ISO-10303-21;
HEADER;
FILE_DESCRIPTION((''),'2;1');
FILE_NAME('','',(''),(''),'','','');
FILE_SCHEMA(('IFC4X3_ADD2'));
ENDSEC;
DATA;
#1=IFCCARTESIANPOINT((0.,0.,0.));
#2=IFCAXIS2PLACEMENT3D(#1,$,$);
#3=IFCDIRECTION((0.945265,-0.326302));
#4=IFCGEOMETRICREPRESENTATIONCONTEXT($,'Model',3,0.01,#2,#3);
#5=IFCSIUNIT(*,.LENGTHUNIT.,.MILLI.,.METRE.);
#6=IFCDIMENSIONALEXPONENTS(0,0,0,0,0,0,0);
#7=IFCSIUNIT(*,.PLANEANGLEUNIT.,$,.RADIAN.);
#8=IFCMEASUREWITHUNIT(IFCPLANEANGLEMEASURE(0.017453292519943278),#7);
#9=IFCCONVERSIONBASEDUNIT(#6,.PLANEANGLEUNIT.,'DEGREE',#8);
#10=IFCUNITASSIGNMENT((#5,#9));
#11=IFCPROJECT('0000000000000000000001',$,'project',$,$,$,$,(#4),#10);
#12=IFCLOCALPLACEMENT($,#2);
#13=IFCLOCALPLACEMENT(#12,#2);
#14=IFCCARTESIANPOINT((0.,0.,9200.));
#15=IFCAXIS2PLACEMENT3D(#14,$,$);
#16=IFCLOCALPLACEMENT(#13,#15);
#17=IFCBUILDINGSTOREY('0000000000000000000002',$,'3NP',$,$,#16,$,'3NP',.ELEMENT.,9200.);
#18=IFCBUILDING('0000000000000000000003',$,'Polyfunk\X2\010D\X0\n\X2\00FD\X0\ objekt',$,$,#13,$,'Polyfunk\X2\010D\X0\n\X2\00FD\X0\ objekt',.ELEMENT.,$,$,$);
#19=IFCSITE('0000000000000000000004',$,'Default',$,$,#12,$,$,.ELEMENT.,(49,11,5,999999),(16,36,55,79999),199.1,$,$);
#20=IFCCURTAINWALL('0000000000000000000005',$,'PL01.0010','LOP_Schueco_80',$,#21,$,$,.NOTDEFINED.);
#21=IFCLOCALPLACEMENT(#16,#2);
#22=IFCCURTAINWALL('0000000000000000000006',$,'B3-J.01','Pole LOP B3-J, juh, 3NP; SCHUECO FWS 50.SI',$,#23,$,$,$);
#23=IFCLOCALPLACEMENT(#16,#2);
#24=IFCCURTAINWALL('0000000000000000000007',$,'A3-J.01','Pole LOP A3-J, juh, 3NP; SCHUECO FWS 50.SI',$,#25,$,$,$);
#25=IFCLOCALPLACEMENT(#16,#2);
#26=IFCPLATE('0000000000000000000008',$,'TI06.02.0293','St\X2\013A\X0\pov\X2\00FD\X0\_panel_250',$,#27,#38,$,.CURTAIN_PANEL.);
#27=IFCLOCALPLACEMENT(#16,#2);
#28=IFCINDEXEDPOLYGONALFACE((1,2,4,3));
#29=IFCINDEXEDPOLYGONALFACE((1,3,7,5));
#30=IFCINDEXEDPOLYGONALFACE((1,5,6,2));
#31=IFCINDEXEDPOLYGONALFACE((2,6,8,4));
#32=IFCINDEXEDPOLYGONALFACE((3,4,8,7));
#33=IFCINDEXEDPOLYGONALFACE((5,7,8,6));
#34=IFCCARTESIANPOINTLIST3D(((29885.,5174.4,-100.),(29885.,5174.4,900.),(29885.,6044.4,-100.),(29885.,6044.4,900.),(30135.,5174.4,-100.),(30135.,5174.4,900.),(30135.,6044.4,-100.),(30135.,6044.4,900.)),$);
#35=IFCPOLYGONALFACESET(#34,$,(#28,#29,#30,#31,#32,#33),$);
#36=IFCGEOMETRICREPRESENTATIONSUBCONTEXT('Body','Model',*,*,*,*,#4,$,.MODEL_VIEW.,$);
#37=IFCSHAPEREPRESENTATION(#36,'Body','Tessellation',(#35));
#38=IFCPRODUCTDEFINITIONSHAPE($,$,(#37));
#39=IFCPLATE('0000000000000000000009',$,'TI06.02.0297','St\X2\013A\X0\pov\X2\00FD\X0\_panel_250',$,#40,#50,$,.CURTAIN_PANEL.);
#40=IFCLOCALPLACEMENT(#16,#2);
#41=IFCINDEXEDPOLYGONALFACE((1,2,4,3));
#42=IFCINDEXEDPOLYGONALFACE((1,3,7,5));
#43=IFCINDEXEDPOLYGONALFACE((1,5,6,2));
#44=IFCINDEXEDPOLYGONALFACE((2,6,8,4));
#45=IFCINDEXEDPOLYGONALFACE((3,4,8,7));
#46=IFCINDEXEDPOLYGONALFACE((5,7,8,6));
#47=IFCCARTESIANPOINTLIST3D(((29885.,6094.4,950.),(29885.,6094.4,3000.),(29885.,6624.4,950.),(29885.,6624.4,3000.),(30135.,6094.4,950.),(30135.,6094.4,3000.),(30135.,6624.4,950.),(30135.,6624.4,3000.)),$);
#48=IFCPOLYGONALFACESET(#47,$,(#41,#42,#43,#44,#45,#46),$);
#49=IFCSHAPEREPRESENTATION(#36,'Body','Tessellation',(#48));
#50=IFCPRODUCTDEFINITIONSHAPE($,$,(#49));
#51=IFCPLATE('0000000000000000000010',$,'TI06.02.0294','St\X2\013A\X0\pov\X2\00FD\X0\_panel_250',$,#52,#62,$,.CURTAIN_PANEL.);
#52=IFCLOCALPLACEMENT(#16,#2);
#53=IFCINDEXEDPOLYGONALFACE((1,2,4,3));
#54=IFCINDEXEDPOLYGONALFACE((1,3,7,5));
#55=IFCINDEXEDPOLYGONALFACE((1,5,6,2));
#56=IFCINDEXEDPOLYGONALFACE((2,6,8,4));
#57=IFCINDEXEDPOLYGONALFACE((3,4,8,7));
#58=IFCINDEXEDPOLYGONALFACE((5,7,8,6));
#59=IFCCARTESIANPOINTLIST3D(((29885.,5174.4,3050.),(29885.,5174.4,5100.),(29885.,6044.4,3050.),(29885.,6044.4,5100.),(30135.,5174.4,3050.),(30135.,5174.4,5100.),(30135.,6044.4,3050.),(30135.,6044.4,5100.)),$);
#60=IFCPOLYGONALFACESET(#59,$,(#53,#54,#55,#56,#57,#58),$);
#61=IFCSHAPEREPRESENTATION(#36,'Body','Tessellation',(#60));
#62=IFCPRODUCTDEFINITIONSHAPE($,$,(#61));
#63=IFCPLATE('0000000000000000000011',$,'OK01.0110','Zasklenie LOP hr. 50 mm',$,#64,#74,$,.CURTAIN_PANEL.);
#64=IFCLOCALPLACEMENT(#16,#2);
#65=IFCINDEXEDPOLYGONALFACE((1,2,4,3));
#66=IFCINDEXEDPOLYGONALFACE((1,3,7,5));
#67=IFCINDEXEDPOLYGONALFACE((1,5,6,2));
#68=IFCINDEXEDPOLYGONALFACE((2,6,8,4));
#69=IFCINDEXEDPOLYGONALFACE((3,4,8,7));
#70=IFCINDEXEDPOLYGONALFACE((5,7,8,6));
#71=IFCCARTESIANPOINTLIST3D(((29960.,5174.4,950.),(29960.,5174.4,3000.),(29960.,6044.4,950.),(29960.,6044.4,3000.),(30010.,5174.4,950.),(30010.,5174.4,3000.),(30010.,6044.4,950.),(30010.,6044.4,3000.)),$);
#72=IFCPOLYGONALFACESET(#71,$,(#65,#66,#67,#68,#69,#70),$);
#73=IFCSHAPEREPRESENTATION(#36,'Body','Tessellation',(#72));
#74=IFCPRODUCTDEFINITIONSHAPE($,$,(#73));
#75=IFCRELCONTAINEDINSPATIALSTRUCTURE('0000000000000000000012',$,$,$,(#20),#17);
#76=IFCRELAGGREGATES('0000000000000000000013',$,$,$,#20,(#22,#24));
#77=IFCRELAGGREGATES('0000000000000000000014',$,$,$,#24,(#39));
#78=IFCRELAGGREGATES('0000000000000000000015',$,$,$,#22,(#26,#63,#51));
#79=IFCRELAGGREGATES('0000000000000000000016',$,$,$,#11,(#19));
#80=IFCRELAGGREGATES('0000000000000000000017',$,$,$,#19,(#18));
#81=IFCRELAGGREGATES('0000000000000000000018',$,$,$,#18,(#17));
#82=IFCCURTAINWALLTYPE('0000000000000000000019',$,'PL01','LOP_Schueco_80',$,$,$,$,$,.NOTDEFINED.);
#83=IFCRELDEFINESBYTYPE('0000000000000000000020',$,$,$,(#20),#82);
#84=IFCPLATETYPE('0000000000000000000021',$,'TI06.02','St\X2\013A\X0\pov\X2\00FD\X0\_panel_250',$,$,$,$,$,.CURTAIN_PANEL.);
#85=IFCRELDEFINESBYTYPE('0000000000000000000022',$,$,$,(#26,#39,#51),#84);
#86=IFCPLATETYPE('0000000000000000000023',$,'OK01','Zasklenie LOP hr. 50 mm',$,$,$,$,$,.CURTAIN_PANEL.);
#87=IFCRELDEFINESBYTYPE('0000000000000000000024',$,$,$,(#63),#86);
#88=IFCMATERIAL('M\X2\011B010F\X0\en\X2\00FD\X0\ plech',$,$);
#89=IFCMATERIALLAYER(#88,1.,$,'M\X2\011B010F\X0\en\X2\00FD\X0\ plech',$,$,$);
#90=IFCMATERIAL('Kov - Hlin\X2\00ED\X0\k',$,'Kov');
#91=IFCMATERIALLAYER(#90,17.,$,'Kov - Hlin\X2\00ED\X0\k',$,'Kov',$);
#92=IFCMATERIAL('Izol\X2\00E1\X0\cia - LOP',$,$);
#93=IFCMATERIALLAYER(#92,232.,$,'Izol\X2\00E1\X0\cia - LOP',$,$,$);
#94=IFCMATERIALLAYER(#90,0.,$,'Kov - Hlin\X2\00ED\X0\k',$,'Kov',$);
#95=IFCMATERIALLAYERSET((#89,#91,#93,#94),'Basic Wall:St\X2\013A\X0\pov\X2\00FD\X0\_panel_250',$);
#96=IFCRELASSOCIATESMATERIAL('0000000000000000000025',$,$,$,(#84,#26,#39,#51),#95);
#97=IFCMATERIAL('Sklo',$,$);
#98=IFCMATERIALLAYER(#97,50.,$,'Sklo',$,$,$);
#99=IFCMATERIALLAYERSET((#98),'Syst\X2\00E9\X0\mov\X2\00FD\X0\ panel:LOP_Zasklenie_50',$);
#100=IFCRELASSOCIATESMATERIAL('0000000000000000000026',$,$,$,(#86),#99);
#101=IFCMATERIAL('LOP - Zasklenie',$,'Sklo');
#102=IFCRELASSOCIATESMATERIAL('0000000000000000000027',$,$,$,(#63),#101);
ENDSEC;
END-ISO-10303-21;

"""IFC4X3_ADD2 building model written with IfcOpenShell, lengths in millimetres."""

from ifc_helpers import new_model, entity, si_unit, converted_unit, direction, frame, frame_2d, origin, origin_2d_with_axis, place, context, subcontext, project, spatial, rectangle, extrude, source, transform, mapped, material, layer, layer_set, layer_usage, type_object, type_shapes, element, aggregate, save


model = new_model("IFC4X3_ADD2")

# Units and contexts
model_context = context("Model", 3, precision=0.01, world=origin(), true_north=direction((0.945265, -0.326302)))
body_context = subcontext(model_context, "Body", "Model", "MODEL_VIEW")
ifc_project = project(units=[si_unit("LENGTHUNIT", "METRE", prefix="MILLI"), converted_unit("PLANEANGLEUNIT", "DEGREE", entity("IfcPlaneAngleMeasure", 0.017453292519943278), si_unit("PLANEANGLEUNIT", "RADIAN"), dimensions=[0, 0, 0, 0, 0, 0, 0])], contexts=[model_context])

# Site, building, storey
site_placement = place(None, origin())
site = spatial("IfcSite", under=ifc_project, at=site_placement, Name="Default", CompositionType="ELEMENT", RefLatitude=(49, 11, 5, 999999), RefLongitude=(16, 36, 55, 79999), RefElevation=199.1)
building_placement = place(site_placement, origin())
building = spatial("IfcBuilding", under=site, at=building_placement, Name="Polyfunkčný objekt", LongName="Polyfunkčný objekt", CompositionType="ELEMENT")
storey_placement = place(building_placement, frame((0.0, 0.0, 9200.0)))
storey = spatial("IfcBuildingStorey", under=building, at=storey_placement, Name="3NP", LongName="3NP", CompositionType="ELEMENT", Elevation=9200.0)

# Curtain walls, plates
curtain_wall_type = type_object("IfcCurtainWallType", Name="PL01", Description="LOP_Schueco_80", PredefinedType="NOTDEFINED")
curtain_wall_1_placement = place(storey_placement, frame((0.0, 0.0, -9200.0)))
curtain_wall_1 = element("IfcCurtainWall", 1, at=curtain_wall_1_placement, inside=storey, type_object=curtain_wall_type, Name="PL01.0010", Description="LOP_Schueco_80", PredefinedType="NOTDEFINED")
curtain_wall_2 = element("IfcCurtainWall", 2, Name="B3-J.01", Description="Pole LOP B3-J, juh, 3NP; SCHUECO FWS 50.SI")
curtain_wall_3 = element("IfcCurtainWall", 3, Name="A3-J.01", Description="Pole LOP A3-J, juh, 3NP; SCHUECO FWS 50.SI")
aggregate(curtain_wall_1, [curtain_wall_2, curtain_wall_3])
ifc_material_1 = material(Name="Měďený plech")
ifc_layer_1 = layer(ifc_material_1, 1.0, Name="Měďený plech")
ifc_material_2 = material(Name="Kov - Hliník", Category="Kov")
ifc_layer_2 = layer(ifc_material_2, 17.0, Name="Kov - Hliník", Category="Kov")
ifc_material_3 = material(Name="Izolácia - LOP")
ifc_layer_3 = layer(ifc_material_3, 232.0, Name="Izolácia - LOP")
ifc_layer_4 = layer(ifc_material_2, 0.0, Name="Kov - Hliník", Category="Kov")
ifc_layer_set_1 = layer_set([ifc_layer_1, ifc_layer_2, ifc_layer_3, ifc_layer_4], Name="Basic Wall:Stĺpový_panel_250")
ifc_layer_usage_1 = layer_usage(ifc_layer_set_1, "AXIS2", "POSITIVE", -125.0)
plate_type_1 = type_object("IfcPlateType", Name="TI06.02", Description="Stĺpový_panel_250", PredefinedType="CURTAIN_PANEL", material=ifc_layer_set_1)
plate_1_placement = place(storey_placement, frame((30010.0, 6044.4, -100.0), z_axis=(0.0, 0.0, 1.0), x_axis=(0.0, -1.0, 0.0)))
plate_1 = element("IfcPlate", 4, at=plate_1_placement, type_object=plate_type_1, material=ifc_layer_usage_1, Name="TI06.02.0293", Description="Stĺpový_panel_250", PredefinedType="CURTAIN_PANEL", context=body_context, shape_type="SweptSolid", body=[
    extrude(rectangle(XDim=250.0, YDim=870.0, at=frame_2d((0.0, 0.0), x_axis=(1.0, 0.0))), frame((435.0, 0.0, 0.0), z_axis=(0.0, 0.0, 1.0), x_axis=(0.0, 1.0, 0.0)), (0.0, 0.0, 1.0), 1000.0),
])
ifc_layer_usage_2 = layer_usage(ifc_layer_set_1, "AXIS2", "POSITIVE", -125.0)
plate_2_placement = place(storey_placement, frame((30010.0, 6624.4, 950.0), z_axis=(0.0, 0.0, 1.0), x_axis=(0.0, -1.0, 0.0)))
plate_2 = element("IfcPlate", 5, at=plate_2_placement, type_object=plate_type_1, material=ifc_layer_usage_2, Name="TI06.02.0297", Description="Stĺpový_panel_250", PredefinedType="CURTAIN_PANEL", context=body_context, shape_type="SweptSolid", body=[
    extrude(rectangle(XDim=250.0, YDim=530.0, at=frame_2d((0.0, 0.0), x_axis=(1.0, 0.0))), frame((265.0, 0.0, 0.0), z_axis=(0.0, 0.0, 1.0), x_axis=(0.0, 1.0, 0.0)), (0.0, 0.0, 1.0), 2050.0),
])
aggregate(curtain_wall_3, [plate_2])
ifc_layer_usage_3 = layer_usage(ifc_layer_set_1, "AXIS2", "POSITIVE", -125.0)
plate_3_placement = place(storey_placement, frame((30010.0, 6044.4, 3050.0), z_axis=(0.0, 0.0, 1.0), x_axis=(0.0, -1.0, 0.0)))
plate_3 = element("IfcPlate", 6, at=plate_3_placement, type_object=plate_type_1, material=ifc_layer_usage_3, Name="TI06.02.0294", Description="Stĺpový_panel_250", PredefinedType="CURTAIN_PANEL", context=body_context, shape_type="SweptSolid", body=[
    extrude(rectangle(XDim=250.0, YDim=870.0, at=frame_2d((0.0, 0.0), x_axis=(1.0, 0.0))), frame((435.0, 0.0, 0.0), z_axis=(0.0, 0.0, 1.0), x_axis=(0.0, 1.0, 0.0)), (0.0, 0.0, 1.0), 2050.0),
])
ifc_material_4 = material(Name="LOP - Zasklenie", Category="Sklo")
ifc_material_5 = material(Name="Sklo")
ifc_layer_5 = layer(ifc_material_5, 50.0, Name="Sklo")
ifc_layer_set_2 = layer_set([ifc_layer_5], Name="Systémový panel:LOP_Zasklenie_50")
plate_type_2 = type_object("IfcPlateType", Name="OK01", Description="Zasklenie LOP hr. 50 mm", PredefinedType="CURTAIN_PANEL", material=ifc_layer_set_2)
shared_shape_1 = source(origin(), body_context, "Body", "SweptSolid", [
    extrude(rectangle(XDim=50.0, YDim=870.0, at=origin_2d_with_axis()), frame((0.0, -25.0, 0.0), z_axis=(0.0, 0.0, 1.0), x_axis=(0.0, 1.0, 0.0)), (0.0, 0.0, 1.0), 2050.0),
])
type_shapes(plate_type_2, [shared_shape_1])
plate_4_placement = place(curtain_wall_1_placement, frame((30010.0, 5609.4, 10150.0), z_axis=(0.0, 0.0, 1.0), x_axis=(0.0, -1.0, 0.0)))
plate_4 = element("IfcPlate", 7, at=plate_4_placement, type_object=plate_type_2, material=ifc_material_4, Name="OK01.0110", Description="Zasklenie LOP hr. 50 mm", PredefinedType="CURTAIN_PANEL", context=body_context, shape_type="MappedRepresentation", body=[
    mapped(shared_shape_1, transform((0.0, 0.0, 0.0), scale=1.0)),
])
aggregate(curtain_wall_2, [plate_1, plate_4, plate_3])

save(model, "model.ifc")
